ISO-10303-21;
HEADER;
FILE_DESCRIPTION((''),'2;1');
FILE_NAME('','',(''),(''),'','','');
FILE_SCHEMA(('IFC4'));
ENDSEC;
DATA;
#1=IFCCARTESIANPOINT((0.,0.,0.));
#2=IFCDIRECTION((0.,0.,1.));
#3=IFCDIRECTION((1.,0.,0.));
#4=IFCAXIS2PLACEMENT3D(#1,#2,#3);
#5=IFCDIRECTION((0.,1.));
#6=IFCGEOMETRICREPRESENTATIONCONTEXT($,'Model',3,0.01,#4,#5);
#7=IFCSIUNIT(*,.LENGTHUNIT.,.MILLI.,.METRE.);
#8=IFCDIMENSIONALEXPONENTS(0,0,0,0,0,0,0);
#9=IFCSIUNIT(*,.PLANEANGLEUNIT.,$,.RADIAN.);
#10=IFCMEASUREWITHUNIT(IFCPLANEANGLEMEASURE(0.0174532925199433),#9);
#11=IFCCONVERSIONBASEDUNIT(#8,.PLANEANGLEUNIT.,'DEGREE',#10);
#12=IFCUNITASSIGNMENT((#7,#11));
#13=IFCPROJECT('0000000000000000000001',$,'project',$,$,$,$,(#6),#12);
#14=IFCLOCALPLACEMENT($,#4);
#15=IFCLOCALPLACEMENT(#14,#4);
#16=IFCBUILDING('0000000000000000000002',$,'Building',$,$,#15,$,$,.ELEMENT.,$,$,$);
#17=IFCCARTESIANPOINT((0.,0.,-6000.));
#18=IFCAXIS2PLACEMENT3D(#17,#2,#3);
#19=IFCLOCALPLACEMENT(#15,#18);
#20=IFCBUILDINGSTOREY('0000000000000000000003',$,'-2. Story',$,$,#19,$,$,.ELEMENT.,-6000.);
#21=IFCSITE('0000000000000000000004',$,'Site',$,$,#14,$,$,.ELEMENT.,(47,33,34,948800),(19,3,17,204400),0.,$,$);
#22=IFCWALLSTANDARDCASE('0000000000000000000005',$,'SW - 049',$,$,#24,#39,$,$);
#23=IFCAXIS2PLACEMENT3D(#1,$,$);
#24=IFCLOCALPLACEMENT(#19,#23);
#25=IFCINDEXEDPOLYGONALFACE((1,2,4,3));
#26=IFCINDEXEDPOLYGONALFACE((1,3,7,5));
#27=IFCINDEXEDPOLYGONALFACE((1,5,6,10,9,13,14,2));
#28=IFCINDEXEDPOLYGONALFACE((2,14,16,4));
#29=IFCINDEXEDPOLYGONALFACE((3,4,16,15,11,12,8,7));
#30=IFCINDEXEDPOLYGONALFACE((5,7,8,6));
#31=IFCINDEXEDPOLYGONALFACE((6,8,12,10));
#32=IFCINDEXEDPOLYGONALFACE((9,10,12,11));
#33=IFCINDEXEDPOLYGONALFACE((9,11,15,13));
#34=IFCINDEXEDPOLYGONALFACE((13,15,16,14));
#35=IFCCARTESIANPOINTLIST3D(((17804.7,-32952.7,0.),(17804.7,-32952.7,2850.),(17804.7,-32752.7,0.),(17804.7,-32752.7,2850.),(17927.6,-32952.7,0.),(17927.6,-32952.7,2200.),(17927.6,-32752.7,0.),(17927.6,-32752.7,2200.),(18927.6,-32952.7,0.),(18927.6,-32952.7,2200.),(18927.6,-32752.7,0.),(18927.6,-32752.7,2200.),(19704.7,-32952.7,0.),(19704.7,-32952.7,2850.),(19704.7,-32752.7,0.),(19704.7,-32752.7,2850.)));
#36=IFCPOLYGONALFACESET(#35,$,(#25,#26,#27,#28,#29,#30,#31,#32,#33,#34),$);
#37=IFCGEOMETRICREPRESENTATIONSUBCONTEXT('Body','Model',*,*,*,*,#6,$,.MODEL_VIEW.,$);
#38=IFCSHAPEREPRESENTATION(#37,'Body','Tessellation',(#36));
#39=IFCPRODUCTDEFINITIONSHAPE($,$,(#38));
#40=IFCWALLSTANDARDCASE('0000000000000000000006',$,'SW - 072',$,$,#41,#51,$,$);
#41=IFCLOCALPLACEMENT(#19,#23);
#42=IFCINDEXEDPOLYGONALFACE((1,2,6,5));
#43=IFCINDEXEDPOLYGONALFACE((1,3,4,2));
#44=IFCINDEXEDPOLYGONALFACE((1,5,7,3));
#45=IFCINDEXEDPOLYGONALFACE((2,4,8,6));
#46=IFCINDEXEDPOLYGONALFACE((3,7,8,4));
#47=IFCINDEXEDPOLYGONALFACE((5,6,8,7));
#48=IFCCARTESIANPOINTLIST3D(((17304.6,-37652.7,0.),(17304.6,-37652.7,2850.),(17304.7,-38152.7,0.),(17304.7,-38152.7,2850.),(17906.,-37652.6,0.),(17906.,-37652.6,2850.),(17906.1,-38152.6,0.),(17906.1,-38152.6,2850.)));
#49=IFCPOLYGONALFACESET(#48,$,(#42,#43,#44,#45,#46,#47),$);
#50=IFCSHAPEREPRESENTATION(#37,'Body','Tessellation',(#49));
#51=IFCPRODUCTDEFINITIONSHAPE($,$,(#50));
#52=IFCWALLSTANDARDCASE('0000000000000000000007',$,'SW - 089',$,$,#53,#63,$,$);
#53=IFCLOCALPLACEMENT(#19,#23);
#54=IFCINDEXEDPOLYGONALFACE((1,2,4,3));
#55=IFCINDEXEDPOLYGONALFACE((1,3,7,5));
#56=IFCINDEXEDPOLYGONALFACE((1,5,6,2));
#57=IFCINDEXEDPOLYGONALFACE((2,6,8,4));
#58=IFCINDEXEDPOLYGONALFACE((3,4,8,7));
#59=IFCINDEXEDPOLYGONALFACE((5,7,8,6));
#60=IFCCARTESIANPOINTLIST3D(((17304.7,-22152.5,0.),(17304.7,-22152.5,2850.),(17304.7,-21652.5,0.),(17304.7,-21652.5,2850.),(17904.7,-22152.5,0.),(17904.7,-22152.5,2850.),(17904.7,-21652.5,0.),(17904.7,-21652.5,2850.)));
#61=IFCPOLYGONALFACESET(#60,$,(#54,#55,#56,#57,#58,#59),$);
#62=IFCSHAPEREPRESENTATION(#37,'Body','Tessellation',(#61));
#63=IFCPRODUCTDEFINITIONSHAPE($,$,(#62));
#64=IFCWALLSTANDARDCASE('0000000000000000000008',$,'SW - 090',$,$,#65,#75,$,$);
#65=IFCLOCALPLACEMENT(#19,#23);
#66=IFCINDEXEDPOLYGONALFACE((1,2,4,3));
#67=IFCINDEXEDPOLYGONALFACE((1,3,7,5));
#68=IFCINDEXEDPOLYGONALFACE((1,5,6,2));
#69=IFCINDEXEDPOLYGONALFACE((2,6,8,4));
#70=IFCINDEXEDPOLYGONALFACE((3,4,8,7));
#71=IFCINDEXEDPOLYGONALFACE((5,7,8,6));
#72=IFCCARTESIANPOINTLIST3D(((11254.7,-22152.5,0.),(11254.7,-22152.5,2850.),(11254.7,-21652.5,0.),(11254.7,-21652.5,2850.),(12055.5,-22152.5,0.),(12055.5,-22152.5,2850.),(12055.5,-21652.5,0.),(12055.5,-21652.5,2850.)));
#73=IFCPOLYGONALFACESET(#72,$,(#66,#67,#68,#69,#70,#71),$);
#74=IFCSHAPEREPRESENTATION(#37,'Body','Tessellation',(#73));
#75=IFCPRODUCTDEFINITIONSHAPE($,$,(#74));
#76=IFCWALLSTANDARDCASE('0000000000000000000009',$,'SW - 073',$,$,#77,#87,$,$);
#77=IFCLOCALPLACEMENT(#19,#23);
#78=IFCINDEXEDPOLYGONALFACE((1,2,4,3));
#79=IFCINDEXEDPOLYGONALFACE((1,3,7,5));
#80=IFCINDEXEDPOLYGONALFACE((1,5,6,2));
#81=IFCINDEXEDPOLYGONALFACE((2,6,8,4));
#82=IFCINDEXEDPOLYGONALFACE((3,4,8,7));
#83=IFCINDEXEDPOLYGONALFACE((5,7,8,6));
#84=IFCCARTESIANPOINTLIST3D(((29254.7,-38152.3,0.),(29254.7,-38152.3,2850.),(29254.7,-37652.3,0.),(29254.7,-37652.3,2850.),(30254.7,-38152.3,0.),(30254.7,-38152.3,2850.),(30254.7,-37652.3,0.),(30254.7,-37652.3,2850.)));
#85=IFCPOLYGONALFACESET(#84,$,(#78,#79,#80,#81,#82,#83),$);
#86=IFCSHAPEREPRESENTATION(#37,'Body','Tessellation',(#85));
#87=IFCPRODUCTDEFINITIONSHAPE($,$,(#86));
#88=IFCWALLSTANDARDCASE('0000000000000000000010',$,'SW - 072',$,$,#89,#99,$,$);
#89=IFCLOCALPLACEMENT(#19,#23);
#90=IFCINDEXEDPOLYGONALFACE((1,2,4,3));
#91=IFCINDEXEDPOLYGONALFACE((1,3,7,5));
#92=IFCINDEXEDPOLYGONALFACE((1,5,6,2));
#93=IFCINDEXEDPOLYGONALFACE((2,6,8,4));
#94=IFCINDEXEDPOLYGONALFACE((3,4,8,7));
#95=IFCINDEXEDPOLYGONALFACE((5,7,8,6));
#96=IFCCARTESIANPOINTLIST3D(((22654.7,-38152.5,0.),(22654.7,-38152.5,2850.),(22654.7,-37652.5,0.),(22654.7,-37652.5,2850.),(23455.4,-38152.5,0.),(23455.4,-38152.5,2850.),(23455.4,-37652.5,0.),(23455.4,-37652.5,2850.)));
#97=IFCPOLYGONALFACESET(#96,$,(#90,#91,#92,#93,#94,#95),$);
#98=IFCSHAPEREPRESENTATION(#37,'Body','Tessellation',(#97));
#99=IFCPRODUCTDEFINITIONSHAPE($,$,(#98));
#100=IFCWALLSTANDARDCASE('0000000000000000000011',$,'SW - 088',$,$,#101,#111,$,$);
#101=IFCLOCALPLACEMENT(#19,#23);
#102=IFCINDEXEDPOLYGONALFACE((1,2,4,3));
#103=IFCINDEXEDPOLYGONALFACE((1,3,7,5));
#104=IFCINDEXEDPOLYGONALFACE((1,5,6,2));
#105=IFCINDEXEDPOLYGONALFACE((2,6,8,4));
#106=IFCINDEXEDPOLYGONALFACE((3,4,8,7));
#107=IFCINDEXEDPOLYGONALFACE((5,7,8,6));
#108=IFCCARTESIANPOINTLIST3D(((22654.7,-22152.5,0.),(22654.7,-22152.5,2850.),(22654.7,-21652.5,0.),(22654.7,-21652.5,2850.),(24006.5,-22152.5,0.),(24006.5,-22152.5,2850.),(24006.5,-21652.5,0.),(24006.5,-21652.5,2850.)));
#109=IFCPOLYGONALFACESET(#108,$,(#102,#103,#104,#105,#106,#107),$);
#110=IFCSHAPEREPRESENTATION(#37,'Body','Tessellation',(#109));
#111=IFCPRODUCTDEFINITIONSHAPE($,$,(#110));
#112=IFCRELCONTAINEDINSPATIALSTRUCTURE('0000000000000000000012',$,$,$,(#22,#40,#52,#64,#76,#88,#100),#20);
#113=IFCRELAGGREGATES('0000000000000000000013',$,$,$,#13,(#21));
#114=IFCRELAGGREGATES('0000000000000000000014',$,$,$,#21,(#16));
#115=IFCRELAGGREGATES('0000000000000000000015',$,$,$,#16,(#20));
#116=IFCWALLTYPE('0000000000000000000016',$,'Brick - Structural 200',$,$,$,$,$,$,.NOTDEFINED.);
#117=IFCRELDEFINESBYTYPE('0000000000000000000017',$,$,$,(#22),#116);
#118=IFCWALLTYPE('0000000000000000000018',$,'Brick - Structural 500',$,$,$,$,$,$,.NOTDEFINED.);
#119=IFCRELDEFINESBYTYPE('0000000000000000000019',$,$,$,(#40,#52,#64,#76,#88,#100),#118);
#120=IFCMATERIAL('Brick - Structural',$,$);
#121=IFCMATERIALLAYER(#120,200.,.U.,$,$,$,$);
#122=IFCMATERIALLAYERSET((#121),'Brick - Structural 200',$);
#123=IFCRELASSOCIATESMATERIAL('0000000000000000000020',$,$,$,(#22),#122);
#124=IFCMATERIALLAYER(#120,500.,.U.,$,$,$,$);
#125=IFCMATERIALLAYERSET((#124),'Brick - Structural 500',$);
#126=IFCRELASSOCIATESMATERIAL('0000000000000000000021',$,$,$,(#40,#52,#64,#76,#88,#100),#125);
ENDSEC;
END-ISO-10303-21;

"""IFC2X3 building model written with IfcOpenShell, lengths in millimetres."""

from ifc_helpers import new_model, entity, si_unit, converted_unit, direction, frame, origin_with_axes, origin_2d_with_axis, place, context, subcontext, project, spatial, polyline, rectangle, outline, extrude, material, layer, layer_set, layer_usage, type_object, element, save


model = new_model("IFC2X3")

# Units and contexts
model_context = context("Model", 3, precision=0.01, world=origin_with_axes(), true_north=direction((0.0, 1.0)))
body_context = subcontext(model_context, "Body", "Model", "MODEL_VIEW")
ifc_project = project(units=[si_unit("LENGTHUNIT", "METRE", prefix="MILLI"), converted_unit("PLANEANGLEUNIT", "DEGREE", entity("IfcPlaneAngleMeasure", 0.0174532925199433), si_unit("PLANEANGLEUNIT", "RADIAN"), dimensions=[0, 0, 0, 0, 0, 0, 0])], contexts=[model_context])

# Site, building, storey
site_placement = place(None, origin_with_axes())
site = spatial("IfcSite", under=ifc_project, at=site_placement, Name="Site", CompositionType="ELEMENT", RefLatitude=(47, 33, 34, 948800), RefLongitude=(19, 3, 17, 204400), RefElevation=0.0)
building_placement = place(site_placement, origin_with_axes())
building = spatial("IfcBuilding", under=site, at=building_placement, Name="Building", CompositionType="ELEMENT")
storey_placement = place(building_placement, frame((0.0, 0.0, -6000.0), z_axis=(0.0, 0.0, 1.0), x_axis=(1.0, 0.0, 0.0)))
storey = spatial("IfcBuildingStorey", under=building, at=storey_placement, Name="-2. Story", CompositionType="ELEMENT", Elevation=-6000.0)

# Shared definitions
ifc_material_1 = material(Name="Brick - Structural")

# Wall, opening
ifc_layer_1 = layer(ifc_material_1, 200.0, ventilated="UNKNOWN")
ifc_layer_set_1 = layer_set([ifc_layer_1], Name="Brick - Structural 200")
ifc_layer_usage_1 = layer_usage(ifc_layer_set_1, "AXIS2", "POSITIVE", 0.0)
wall_type_1 = type_object("IfcWallType", Name="Brick - Structural 200", PredefinedType="NOTDEFINED")
wall_1_placement = place(storey_placement, frame((19704.7, -32752.7, 0.0), z_axis=(0.0, 0.0, 1.0), x_axis=(-1.0, 0.0, 0.0)))
wall_1 = element("IfcWallStandardCase", 1, at=wall_1_placement, inside=storey, type_object=wall_type_1, material=ifc_layer_usage_1, Name="SW - 049", context=body_context, shape_type="SweptSolid", body=[
    extrude(outline(polyline([(0.0, 0.0), (1900.0, 0.0), (1900.0, 200.0), (0.0, 200.0), (0.0, 0.0)])), origin_with_axes(), (0.0, 0.0, 1.0), 2850.0),
])
opening_1_placement = place(wall_1_placement, frame((1277.0, 0.0, 0.0), z_axis=(0.0, 0.0, 1.0), x_axis=(1.0, 0.0, 0.0)))
element("IfcOpeningElement", 2, at=opening_1_placement, cuts=wall_1, context=body_context, shape_type="SweptSolid", body=[
    extrude(rectangle(XDim=1000.0, YDim=2200.0, at=origin_2d_with_axis()), frame((0.0, 200.0, 1100.0), z_axis=(0.0, -1.0, 0.0), x_axis=(1.0, 0.0, 0.0)), (0.0, 0.0, -1.0), 200.0),
    extrude(rectangle(XDim=1000.0, YDim=2200.0, at=origin_2d_with_axis()), frame((0.0, 200.0, 1100.0), z_axis=(0.0, 1.0, 0.0), x_axis=(1.0, 0.0, 0.0)), (0.0, 0.0, -1.0), 200.0),
])

# Walls
ifc_layer_2 = layer(ifc_material_1, 500.0, ventilated="UNKNOWN")
ifc_layer_set_2 = layer_set([ifc_layer_2], Name="Brick - Structural 500")
ifc_layer_usage_2 = layer_usage(ifc_layer_set_2, "AXIS2", "POSITIVE", 0.0)
wall_type_2 = type_object("IfcWallType", Name="Brick - Structural 500", PredefinedType="NOTDEFINED")
wall_2_placement = place(storey_placement, frame((17304.7, -38152.7, 0.0), z_axis=(0.0, 0.0, 1.0), x_axis=(1.0, 0.000161, 0.0)))
element("IfcWallStandardCase", 3, at=wall_2_placement, inside=storey, type_object=wall_type_2, material=ifc_layer_usage_2, Name="SW - 072", context=body_context, shape_type="SweptSolid", body=[
    extrude(outline(polyline([(0.0, 0.0), (601.4, 0.0), (601.4, 500.0), (0.0, 500.0), (0.0, 0.0)])), origin_with_axes(), (0.0, 0.0, 1.0), 2850.0),
])
ifc_layer_usage_3 = layer_usage(ifc_layer_set_2, "AXIS2", "POSITIVE", 0.0)
wall_3_placement = place(storey_placement, frame((17904.7, -21652.5, 0.0), z_axis=(0.0, 0.0, 1.0), x_axis=(-1.0, 0.0, 0.0)))
element("IfcWallStandardCase", 4, at=wall_3_placement, inside=storey, type_object=wall_type_2, material=ifc_layer_usage_3, Name="SW - 089", context=body_context, shape_type="SweptSolid", body=[
    extrude(outline(polyline([(0.0, 0.0), (600.0, 0.0), (600.0, 500.0), (0.0, 500.0), (0.0, 0.0)])), origin_with_axes(), (0.0, 0.0, 1.0), 2850.0),
])
ifc_layer_usage_4 = layer_usage(ifc_layer_set_2, "AXIS2", "POSITIVE", 0.0)
wall_4_placement = place(storey_placement, frame((12055.5, -21652.5, 0.0), z_axis=(0.0, 0.0, 1.0), x_axis=(-1.0, 0.0, 0.0)))
element("IfcWallStandardCase", 5, at=wall_4_placement, inside=storey, type_object=wall_type_2, material=ifc_layer_usage_4, Name="SW - 090", context=body_context, shape_type="SweptSolid", body=[
    extrude(outline(polyline([(0.0, 0.0), (800.8, 0.0), (800.8, 500.0), (0.0, 500.0), (0.0, 0.0)])), origin_with_axes(), (0.0, 0.0, 1.0), 2850.0),
])
ifc_layer_usage_5 = layer_usage(ifc_layer_set_2, "AXIS2", "POSITIVE", 0.0)
wall_5_placement = place(storey_placement, frame((29254.7, -38152.3, 0.0), z_axis=(0.0, 0.0, 1.0), x_axis=(1.0, 0.0, 0.0)))
element("IfcWallStandardCase", 6, at=wall_5_placement, inside=storey, type_object=wall_type_2, material=ifc_layer_usage_5, Name="SW - 073", context=body_context, shape_type="SweptSolid", body=[
    extrude(outline(polyline([(0.0, 0.0), (1000.0, 0.0), (1000.0, 500.0), (0.0, 500.0), (0.0, 0.0)])), origin_with_axes(), (0.0, 0.0, 1.0), 2850.0),
])
ifc_layer_usage_6 = layer_usage(ifc_layer_set_2, "AXIS2", "POSITIVE", 0.0)
wall_6_placement = place(storey_placement, frame((22654.7, -38152.5, 0.0), z_axis=(0.0, 0.0, 1.0), x_axis=(1.0, 0.0, 0.0)))
element("IfcWallStandardCase", 7, at=wall_6_placement, inside=storey, type_object=wall_type_2, material=ifc_layer_usage_6, Name="SW - 072", context=body_context, shape_type="SweptSolid", body=[
    extrude(outline(polyline([(0.0, 0.0), (800.7, 0.0), (800.7, 500.0), (0.0, 500.0), (0.0, 0.0)])), origin_with_axes(), (0.0, 0.0, 1.0), 2850.0),
])
ifc_layer_usage_7 = layer_usage(ifc_layer_set_2, "AXIS2", "POSITIVE", 0.0)
wall_7_placement = place(storey_placement, frame((24006.5, -21652.5, 0.0), z_axis=(0.0, 0.0, 1.0), x_axis=(-1.0, 0.0, 0.0)))
element("IfcWallStandardCase", 8, at=wall_7_placement, inside=storey, type_object=wall_type_2, material=ifc_layer_usage_7, Name="SW - 088", context=body_context, shape_type="SweptSolid", body=[
    extrude(outline(polyline([(0.0, 0.0), (1351.8, 0.0), (1351.8, 500.0), (0.0, 500.0), (0.0, 0.0)])), origin_with_axes(), (0.0, 0.0, 1.0), 2850.0),
])

save(model, "model.ifc")
